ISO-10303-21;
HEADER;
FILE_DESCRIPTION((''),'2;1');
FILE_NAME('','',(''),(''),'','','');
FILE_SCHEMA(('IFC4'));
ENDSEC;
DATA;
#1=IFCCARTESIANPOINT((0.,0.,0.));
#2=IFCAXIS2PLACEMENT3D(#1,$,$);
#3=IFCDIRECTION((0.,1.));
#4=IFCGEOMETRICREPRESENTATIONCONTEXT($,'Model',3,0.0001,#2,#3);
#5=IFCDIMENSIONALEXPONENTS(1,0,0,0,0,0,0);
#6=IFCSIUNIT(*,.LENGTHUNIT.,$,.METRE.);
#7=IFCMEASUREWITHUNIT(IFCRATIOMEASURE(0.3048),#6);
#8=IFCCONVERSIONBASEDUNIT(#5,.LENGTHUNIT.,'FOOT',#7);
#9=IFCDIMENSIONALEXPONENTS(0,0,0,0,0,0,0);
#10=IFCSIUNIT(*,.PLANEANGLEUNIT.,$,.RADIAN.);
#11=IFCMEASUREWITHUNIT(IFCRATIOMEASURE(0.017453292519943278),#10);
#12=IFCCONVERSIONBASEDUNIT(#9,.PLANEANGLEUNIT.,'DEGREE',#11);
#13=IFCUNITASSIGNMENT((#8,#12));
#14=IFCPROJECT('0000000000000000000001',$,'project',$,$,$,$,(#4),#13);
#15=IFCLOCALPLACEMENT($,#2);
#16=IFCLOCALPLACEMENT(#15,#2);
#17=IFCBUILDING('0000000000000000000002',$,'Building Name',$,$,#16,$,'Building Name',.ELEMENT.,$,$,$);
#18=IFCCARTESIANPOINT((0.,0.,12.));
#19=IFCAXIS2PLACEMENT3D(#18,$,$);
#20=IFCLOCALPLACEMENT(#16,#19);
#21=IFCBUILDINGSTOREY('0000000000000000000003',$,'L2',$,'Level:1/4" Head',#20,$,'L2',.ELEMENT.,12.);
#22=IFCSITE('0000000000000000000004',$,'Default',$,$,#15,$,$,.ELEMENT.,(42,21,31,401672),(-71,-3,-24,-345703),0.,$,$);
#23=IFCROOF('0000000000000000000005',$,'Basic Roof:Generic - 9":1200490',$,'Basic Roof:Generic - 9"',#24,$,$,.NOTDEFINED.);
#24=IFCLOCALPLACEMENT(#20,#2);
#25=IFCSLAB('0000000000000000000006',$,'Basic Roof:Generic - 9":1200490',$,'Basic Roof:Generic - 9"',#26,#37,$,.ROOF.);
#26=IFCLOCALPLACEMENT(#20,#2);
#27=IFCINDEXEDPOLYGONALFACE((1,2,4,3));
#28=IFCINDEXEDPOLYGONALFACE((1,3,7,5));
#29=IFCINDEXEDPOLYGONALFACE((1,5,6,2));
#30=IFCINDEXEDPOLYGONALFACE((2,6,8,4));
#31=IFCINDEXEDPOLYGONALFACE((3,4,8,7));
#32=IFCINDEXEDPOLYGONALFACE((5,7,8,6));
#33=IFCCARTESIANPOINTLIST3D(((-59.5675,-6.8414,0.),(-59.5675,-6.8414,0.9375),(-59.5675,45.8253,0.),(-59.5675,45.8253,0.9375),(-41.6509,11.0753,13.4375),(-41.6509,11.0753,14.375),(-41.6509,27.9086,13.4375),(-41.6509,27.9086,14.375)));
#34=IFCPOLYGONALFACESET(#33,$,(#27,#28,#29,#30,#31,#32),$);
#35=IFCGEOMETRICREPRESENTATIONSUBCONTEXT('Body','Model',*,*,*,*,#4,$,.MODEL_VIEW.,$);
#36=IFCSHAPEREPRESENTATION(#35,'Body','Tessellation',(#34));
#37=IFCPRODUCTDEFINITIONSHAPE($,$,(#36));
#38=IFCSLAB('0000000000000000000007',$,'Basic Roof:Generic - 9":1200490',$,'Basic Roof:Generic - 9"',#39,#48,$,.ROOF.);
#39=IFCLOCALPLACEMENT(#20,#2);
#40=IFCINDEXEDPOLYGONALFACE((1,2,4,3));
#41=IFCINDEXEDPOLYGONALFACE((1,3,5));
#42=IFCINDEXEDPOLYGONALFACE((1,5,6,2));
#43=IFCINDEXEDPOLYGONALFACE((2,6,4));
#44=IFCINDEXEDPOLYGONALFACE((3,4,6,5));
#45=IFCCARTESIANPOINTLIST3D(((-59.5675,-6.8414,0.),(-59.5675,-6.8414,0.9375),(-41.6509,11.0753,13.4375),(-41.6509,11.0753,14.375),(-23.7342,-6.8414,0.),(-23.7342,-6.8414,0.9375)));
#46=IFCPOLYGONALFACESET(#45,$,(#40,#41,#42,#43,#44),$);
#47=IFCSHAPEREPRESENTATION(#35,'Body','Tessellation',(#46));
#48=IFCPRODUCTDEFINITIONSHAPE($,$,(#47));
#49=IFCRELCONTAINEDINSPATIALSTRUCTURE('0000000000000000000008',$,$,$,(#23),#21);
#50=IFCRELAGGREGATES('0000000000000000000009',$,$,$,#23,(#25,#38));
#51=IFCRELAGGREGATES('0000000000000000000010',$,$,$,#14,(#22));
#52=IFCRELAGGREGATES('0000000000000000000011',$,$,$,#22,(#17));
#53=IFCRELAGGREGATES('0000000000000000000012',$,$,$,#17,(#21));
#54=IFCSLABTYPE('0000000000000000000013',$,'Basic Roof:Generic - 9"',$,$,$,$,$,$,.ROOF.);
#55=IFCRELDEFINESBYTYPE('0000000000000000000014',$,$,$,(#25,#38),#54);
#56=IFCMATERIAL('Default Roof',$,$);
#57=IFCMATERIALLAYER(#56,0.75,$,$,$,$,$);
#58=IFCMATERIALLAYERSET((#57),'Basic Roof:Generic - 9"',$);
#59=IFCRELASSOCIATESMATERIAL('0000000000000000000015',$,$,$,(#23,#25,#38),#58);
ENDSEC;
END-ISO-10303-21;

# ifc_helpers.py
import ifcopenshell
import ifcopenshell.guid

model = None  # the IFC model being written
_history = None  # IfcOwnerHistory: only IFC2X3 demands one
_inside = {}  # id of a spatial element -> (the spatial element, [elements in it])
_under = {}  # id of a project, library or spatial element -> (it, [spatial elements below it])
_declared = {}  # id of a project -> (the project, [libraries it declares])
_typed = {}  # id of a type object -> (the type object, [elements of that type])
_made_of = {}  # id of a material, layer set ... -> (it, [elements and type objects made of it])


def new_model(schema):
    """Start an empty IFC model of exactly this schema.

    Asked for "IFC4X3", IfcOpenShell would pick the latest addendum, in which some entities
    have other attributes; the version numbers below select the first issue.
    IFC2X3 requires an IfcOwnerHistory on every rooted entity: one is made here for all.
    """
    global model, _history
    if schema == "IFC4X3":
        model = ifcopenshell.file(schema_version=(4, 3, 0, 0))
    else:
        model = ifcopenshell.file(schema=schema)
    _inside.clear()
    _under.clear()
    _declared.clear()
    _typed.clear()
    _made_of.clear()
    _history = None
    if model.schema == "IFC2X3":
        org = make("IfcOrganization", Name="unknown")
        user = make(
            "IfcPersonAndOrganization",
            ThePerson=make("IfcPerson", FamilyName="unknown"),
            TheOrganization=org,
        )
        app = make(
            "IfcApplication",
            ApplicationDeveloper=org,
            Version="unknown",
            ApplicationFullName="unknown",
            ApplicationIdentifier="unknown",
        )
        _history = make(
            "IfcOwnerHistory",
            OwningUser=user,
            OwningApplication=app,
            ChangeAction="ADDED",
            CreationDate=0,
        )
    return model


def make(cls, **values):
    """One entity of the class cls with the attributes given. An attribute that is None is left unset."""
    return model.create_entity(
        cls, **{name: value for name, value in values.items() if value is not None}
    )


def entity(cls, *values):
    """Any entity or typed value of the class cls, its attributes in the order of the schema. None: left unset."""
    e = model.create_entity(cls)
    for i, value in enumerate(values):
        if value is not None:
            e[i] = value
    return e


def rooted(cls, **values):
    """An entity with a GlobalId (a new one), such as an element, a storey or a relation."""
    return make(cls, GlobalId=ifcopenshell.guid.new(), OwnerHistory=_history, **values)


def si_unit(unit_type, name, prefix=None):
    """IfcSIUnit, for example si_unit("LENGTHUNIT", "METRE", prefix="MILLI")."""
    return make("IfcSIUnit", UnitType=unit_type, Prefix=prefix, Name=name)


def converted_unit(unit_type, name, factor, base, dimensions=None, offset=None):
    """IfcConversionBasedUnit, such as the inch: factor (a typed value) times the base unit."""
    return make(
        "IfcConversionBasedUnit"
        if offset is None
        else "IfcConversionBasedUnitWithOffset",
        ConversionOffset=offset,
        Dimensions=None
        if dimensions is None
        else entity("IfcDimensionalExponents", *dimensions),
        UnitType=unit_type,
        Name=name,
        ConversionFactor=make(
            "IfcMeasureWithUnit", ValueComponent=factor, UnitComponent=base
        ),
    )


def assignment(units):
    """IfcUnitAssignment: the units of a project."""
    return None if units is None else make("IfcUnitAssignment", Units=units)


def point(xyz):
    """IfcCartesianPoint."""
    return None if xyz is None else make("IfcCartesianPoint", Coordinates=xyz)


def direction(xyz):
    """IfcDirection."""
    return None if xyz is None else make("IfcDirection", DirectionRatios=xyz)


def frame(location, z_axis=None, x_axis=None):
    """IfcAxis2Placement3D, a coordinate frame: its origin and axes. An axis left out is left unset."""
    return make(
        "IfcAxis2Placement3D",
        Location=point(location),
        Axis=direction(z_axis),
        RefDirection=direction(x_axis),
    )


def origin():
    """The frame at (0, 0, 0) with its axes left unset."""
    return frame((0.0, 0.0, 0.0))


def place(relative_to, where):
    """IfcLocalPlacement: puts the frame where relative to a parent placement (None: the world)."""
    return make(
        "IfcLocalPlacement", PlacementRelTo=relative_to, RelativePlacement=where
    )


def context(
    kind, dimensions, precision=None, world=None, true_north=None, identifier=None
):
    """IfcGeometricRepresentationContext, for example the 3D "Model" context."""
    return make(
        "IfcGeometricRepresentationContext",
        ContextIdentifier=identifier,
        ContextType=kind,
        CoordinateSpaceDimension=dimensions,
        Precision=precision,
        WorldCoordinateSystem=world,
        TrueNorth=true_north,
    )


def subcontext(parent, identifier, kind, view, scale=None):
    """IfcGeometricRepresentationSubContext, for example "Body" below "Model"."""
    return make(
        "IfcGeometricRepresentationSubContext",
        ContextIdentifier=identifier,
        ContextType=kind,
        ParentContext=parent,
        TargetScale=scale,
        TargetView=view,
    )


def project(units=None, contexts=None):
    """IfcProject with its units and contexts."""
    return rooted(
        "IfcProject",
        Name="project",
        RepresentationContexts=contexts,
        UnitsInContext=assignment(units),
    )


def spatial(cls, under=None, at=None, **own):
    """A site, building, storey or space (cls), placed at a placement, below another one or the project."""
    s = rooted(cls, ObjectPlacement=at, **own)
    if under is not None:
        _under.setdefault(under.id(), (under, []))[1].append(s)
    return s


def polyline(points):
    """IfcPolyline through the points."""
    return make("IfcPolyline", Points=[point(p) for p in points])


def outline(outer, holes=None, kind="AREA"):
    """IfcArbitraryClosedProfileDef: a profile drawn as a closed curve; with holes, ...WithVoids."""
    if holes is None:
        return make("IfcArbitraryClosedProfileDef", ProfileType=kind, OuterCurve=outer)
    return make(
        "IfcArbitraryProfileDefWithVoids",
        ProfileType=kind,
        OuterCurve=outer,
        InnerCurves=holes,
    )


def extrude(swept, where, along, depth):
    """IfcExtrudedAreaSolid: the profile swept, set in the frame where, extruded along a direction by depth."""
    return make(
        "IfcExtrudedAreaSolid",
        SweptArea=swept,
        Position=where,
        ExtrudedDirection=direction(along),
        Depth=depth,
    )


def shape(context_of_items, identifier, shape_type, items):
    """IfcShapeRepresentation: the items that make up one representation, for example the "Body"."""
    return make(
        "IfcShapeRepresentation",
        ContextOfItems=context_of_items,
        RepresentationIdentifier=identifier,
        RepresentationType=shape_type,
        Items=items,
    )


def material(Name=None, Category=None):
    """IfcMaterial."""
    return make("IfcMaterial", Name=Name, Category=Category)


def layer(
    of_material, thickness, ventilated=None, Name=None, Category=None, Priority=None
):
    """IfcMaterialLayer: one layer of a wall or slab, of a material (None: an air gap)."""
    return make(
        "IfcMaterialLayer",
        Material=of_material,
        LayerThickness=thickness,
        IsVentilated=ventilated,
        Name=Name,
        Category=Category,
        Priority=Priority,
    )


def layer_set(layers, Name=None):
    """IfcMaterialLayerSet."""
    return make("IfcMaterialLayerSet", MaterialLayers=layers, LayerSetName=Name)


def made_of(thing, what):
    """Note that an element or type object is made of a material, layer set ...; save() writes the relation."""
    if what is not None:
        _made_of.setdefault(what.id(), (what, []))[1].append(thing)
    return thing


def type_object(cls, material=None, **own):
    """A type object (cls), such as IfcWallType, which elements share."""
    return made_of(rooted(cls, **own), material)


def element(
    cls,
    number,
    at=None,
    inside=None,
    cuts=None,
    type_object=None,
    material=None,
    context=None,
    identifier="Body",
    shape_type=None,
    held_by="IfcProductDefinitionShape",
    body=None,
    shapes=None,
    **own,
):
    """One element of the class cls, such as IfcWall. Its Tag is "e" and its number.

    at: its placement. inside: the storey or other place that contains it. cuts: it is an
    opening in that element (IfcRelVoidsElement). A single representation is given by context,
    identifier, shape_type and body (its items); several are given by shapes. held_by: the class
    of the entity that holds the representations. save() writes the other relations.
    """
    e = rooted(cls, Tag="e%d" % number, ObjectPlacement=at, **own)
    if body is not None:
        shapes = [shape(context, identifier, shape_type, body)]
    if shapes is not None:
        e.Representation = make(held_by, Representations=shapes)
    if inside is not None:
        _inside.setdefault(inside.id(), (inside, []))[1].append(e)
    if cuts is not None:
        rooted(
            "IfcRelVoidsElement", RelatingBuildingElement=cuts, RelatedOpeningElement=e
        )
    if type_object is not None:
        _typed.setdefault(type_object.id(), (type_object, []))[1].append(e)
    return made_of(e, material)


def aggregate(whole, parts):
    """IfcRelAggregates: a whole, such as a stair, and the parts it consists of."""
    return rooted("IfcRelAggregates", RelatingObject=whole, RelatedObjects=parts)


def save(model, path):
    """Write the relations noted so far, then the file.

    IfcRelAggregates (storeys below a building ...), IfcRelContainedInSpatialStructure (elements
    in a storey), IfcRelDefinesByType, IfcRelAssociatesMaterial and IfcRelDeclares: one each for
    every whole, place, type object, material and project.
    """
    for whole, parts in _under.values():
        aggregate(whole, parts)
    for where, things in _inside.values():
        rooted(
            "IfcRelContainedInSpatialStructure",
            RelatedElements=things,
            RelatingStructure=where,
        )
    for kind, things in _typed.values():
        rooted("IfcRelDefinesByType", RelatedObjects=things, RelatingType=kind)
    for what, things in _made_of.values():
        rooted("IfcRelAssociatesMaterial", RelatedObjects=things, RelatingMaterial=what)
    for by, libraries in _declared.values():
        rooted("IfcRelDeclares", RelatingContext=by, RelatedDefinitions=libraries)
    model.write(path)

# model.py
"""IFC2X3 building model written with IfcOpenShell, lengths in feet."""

from ifc_helpers import new_model, entity, si_unit, converted_unit, direction, frame, origin, place, context, subcontext, project, spatial, polyline, outline, extrude, material, layer, layer_set, type_object, element, aggregate, save


model = new_model("IFC2X3")

# Units and contexts
model_context = context("Model", 3, precision=0.0001, world=origin(), true_north=direction((0.0, 1.0)))
body_context = subcontext(model_context, "Body", "Model", "MODEL_VIEW")
ifc_project = project(units=[converted_unit("LENGTHUNIT", "FOOT", entity("IfcRatioMeasure", 0.3048), si_unit("LENGTHUNIT", "METRE"), dimensions=[1, 0, 0, 0, 0, 0, 0]), converted_unit("PLANEANGLEUNIT", "DEGREE", entity("IfcRatioMeasure", 0.017453292519943278), si_unit("PLANEANGLEUNIT", "RADIAN"), dimensions=[0, 0, 0, 0, 0, 0, 0])], contexts=[model_context])

# Site, building, storey
site_placement = place(None, origin())
site = spatial("IfcSite", under=ifc_project, at=site_placement, Name="Default", CompositionType="ELEMENT", RefLatitude=(42, 21, 31, 401672), RefLongitude=(-71, -3, -24, -345703), RefElevation=0.0)
building_placement = place(site_placement, origin())
building = spatial("IfcBuilding", under=site, at=building_placement, Name="Building Name", LongName="Building Name", CompositionType="ELEMENT")
storey_placement = place(building_placement, frame((0.0, 0.0, 12.0)))
storey = spatial("IfcBuildingStorey", under=building, at=storey_placement, Name="L2", ObjectType="Level:1/4\" Head", LongName="L2", CompositionType="ELEMENT", Elevation=12.0)

# Roof, slabs
ifc_material = material(Name="Default Roof")
ifc_layer = layer(ifc_material, 0.75)
ifc_layer_set = layer_set([ifc_layer], Name="Basic Roof:Generic - 9\"")
roof_placement = place(storey_placement, frame((-59.5675, -6.8414, 0.0)))
roof = element("IfcRoof", 1, at=roof_placement, inside=storey, material=ifc_layer_set, Name="Basic Roof:Generic - 9\":1200490", ObjectType="Basic Roof:Generic - 9\"", ShapeType="NOTDEFINED")
slab_type = type_object("IfcSlabType", Name="Basic Roof:Generic - 9\"", PredefinedType="ROOF")
slab_1_placement = place(roof_placement, origin())
slab_1 = element("IfcSlab", 2, at=slab_1_placement, type_object=slab_type, material=ifc_layer_set, Name="Basic Roof:Generic - 9\":1200490", ObjectType="Basic Roof:Generic - 9\"", PredefinedType="ROOF", context=body_context, shape_type="SweptSolid", body=[
    extrude(outline(polyline([(11.1979, -8.4167), (11.1979, 8.4167), (-11.1979, 26.3333), (-11.1979, -26.3333), (11.1979, -8.4167)])), frame((8.9583, 26.3333, 6.7188), z_axis=(-0.6, 0.0, 0.8), x_axis=(0.8, 0.0, 0.6)), (0.6, 0.0, 0.8), 0.9375),
])
slab_2_placement = place(roof_placement, origin())
slab_2 = element("IfcSlab", 3, at=slab_2_placement, type_object=slab_type, material=ifc_layer_set, Name="Basic Roof:Generic - 9\":1200490", ObjectType="Basic Roof:Generic - 9\"", PredefinedType="ROOF", context=body_context, shape_type="SweptSolid", body=[
    extrude(outline(polyline([(-17.9167, -11.1979), (17.9167, -11.1979), (0.0, 11.1979), (-17.9167, -11.1979)])), frame((17.9167, 8.9583, 6.7188), z_axis=(0.0, -0.6, 0.8), x_axis=(1.0, 0.0, 0.0)), (0.0, 0.6, 0.8), 0.9375),
])
aggregate(roof, [slab_1, slab_2])

save(model, "model.ifc")
